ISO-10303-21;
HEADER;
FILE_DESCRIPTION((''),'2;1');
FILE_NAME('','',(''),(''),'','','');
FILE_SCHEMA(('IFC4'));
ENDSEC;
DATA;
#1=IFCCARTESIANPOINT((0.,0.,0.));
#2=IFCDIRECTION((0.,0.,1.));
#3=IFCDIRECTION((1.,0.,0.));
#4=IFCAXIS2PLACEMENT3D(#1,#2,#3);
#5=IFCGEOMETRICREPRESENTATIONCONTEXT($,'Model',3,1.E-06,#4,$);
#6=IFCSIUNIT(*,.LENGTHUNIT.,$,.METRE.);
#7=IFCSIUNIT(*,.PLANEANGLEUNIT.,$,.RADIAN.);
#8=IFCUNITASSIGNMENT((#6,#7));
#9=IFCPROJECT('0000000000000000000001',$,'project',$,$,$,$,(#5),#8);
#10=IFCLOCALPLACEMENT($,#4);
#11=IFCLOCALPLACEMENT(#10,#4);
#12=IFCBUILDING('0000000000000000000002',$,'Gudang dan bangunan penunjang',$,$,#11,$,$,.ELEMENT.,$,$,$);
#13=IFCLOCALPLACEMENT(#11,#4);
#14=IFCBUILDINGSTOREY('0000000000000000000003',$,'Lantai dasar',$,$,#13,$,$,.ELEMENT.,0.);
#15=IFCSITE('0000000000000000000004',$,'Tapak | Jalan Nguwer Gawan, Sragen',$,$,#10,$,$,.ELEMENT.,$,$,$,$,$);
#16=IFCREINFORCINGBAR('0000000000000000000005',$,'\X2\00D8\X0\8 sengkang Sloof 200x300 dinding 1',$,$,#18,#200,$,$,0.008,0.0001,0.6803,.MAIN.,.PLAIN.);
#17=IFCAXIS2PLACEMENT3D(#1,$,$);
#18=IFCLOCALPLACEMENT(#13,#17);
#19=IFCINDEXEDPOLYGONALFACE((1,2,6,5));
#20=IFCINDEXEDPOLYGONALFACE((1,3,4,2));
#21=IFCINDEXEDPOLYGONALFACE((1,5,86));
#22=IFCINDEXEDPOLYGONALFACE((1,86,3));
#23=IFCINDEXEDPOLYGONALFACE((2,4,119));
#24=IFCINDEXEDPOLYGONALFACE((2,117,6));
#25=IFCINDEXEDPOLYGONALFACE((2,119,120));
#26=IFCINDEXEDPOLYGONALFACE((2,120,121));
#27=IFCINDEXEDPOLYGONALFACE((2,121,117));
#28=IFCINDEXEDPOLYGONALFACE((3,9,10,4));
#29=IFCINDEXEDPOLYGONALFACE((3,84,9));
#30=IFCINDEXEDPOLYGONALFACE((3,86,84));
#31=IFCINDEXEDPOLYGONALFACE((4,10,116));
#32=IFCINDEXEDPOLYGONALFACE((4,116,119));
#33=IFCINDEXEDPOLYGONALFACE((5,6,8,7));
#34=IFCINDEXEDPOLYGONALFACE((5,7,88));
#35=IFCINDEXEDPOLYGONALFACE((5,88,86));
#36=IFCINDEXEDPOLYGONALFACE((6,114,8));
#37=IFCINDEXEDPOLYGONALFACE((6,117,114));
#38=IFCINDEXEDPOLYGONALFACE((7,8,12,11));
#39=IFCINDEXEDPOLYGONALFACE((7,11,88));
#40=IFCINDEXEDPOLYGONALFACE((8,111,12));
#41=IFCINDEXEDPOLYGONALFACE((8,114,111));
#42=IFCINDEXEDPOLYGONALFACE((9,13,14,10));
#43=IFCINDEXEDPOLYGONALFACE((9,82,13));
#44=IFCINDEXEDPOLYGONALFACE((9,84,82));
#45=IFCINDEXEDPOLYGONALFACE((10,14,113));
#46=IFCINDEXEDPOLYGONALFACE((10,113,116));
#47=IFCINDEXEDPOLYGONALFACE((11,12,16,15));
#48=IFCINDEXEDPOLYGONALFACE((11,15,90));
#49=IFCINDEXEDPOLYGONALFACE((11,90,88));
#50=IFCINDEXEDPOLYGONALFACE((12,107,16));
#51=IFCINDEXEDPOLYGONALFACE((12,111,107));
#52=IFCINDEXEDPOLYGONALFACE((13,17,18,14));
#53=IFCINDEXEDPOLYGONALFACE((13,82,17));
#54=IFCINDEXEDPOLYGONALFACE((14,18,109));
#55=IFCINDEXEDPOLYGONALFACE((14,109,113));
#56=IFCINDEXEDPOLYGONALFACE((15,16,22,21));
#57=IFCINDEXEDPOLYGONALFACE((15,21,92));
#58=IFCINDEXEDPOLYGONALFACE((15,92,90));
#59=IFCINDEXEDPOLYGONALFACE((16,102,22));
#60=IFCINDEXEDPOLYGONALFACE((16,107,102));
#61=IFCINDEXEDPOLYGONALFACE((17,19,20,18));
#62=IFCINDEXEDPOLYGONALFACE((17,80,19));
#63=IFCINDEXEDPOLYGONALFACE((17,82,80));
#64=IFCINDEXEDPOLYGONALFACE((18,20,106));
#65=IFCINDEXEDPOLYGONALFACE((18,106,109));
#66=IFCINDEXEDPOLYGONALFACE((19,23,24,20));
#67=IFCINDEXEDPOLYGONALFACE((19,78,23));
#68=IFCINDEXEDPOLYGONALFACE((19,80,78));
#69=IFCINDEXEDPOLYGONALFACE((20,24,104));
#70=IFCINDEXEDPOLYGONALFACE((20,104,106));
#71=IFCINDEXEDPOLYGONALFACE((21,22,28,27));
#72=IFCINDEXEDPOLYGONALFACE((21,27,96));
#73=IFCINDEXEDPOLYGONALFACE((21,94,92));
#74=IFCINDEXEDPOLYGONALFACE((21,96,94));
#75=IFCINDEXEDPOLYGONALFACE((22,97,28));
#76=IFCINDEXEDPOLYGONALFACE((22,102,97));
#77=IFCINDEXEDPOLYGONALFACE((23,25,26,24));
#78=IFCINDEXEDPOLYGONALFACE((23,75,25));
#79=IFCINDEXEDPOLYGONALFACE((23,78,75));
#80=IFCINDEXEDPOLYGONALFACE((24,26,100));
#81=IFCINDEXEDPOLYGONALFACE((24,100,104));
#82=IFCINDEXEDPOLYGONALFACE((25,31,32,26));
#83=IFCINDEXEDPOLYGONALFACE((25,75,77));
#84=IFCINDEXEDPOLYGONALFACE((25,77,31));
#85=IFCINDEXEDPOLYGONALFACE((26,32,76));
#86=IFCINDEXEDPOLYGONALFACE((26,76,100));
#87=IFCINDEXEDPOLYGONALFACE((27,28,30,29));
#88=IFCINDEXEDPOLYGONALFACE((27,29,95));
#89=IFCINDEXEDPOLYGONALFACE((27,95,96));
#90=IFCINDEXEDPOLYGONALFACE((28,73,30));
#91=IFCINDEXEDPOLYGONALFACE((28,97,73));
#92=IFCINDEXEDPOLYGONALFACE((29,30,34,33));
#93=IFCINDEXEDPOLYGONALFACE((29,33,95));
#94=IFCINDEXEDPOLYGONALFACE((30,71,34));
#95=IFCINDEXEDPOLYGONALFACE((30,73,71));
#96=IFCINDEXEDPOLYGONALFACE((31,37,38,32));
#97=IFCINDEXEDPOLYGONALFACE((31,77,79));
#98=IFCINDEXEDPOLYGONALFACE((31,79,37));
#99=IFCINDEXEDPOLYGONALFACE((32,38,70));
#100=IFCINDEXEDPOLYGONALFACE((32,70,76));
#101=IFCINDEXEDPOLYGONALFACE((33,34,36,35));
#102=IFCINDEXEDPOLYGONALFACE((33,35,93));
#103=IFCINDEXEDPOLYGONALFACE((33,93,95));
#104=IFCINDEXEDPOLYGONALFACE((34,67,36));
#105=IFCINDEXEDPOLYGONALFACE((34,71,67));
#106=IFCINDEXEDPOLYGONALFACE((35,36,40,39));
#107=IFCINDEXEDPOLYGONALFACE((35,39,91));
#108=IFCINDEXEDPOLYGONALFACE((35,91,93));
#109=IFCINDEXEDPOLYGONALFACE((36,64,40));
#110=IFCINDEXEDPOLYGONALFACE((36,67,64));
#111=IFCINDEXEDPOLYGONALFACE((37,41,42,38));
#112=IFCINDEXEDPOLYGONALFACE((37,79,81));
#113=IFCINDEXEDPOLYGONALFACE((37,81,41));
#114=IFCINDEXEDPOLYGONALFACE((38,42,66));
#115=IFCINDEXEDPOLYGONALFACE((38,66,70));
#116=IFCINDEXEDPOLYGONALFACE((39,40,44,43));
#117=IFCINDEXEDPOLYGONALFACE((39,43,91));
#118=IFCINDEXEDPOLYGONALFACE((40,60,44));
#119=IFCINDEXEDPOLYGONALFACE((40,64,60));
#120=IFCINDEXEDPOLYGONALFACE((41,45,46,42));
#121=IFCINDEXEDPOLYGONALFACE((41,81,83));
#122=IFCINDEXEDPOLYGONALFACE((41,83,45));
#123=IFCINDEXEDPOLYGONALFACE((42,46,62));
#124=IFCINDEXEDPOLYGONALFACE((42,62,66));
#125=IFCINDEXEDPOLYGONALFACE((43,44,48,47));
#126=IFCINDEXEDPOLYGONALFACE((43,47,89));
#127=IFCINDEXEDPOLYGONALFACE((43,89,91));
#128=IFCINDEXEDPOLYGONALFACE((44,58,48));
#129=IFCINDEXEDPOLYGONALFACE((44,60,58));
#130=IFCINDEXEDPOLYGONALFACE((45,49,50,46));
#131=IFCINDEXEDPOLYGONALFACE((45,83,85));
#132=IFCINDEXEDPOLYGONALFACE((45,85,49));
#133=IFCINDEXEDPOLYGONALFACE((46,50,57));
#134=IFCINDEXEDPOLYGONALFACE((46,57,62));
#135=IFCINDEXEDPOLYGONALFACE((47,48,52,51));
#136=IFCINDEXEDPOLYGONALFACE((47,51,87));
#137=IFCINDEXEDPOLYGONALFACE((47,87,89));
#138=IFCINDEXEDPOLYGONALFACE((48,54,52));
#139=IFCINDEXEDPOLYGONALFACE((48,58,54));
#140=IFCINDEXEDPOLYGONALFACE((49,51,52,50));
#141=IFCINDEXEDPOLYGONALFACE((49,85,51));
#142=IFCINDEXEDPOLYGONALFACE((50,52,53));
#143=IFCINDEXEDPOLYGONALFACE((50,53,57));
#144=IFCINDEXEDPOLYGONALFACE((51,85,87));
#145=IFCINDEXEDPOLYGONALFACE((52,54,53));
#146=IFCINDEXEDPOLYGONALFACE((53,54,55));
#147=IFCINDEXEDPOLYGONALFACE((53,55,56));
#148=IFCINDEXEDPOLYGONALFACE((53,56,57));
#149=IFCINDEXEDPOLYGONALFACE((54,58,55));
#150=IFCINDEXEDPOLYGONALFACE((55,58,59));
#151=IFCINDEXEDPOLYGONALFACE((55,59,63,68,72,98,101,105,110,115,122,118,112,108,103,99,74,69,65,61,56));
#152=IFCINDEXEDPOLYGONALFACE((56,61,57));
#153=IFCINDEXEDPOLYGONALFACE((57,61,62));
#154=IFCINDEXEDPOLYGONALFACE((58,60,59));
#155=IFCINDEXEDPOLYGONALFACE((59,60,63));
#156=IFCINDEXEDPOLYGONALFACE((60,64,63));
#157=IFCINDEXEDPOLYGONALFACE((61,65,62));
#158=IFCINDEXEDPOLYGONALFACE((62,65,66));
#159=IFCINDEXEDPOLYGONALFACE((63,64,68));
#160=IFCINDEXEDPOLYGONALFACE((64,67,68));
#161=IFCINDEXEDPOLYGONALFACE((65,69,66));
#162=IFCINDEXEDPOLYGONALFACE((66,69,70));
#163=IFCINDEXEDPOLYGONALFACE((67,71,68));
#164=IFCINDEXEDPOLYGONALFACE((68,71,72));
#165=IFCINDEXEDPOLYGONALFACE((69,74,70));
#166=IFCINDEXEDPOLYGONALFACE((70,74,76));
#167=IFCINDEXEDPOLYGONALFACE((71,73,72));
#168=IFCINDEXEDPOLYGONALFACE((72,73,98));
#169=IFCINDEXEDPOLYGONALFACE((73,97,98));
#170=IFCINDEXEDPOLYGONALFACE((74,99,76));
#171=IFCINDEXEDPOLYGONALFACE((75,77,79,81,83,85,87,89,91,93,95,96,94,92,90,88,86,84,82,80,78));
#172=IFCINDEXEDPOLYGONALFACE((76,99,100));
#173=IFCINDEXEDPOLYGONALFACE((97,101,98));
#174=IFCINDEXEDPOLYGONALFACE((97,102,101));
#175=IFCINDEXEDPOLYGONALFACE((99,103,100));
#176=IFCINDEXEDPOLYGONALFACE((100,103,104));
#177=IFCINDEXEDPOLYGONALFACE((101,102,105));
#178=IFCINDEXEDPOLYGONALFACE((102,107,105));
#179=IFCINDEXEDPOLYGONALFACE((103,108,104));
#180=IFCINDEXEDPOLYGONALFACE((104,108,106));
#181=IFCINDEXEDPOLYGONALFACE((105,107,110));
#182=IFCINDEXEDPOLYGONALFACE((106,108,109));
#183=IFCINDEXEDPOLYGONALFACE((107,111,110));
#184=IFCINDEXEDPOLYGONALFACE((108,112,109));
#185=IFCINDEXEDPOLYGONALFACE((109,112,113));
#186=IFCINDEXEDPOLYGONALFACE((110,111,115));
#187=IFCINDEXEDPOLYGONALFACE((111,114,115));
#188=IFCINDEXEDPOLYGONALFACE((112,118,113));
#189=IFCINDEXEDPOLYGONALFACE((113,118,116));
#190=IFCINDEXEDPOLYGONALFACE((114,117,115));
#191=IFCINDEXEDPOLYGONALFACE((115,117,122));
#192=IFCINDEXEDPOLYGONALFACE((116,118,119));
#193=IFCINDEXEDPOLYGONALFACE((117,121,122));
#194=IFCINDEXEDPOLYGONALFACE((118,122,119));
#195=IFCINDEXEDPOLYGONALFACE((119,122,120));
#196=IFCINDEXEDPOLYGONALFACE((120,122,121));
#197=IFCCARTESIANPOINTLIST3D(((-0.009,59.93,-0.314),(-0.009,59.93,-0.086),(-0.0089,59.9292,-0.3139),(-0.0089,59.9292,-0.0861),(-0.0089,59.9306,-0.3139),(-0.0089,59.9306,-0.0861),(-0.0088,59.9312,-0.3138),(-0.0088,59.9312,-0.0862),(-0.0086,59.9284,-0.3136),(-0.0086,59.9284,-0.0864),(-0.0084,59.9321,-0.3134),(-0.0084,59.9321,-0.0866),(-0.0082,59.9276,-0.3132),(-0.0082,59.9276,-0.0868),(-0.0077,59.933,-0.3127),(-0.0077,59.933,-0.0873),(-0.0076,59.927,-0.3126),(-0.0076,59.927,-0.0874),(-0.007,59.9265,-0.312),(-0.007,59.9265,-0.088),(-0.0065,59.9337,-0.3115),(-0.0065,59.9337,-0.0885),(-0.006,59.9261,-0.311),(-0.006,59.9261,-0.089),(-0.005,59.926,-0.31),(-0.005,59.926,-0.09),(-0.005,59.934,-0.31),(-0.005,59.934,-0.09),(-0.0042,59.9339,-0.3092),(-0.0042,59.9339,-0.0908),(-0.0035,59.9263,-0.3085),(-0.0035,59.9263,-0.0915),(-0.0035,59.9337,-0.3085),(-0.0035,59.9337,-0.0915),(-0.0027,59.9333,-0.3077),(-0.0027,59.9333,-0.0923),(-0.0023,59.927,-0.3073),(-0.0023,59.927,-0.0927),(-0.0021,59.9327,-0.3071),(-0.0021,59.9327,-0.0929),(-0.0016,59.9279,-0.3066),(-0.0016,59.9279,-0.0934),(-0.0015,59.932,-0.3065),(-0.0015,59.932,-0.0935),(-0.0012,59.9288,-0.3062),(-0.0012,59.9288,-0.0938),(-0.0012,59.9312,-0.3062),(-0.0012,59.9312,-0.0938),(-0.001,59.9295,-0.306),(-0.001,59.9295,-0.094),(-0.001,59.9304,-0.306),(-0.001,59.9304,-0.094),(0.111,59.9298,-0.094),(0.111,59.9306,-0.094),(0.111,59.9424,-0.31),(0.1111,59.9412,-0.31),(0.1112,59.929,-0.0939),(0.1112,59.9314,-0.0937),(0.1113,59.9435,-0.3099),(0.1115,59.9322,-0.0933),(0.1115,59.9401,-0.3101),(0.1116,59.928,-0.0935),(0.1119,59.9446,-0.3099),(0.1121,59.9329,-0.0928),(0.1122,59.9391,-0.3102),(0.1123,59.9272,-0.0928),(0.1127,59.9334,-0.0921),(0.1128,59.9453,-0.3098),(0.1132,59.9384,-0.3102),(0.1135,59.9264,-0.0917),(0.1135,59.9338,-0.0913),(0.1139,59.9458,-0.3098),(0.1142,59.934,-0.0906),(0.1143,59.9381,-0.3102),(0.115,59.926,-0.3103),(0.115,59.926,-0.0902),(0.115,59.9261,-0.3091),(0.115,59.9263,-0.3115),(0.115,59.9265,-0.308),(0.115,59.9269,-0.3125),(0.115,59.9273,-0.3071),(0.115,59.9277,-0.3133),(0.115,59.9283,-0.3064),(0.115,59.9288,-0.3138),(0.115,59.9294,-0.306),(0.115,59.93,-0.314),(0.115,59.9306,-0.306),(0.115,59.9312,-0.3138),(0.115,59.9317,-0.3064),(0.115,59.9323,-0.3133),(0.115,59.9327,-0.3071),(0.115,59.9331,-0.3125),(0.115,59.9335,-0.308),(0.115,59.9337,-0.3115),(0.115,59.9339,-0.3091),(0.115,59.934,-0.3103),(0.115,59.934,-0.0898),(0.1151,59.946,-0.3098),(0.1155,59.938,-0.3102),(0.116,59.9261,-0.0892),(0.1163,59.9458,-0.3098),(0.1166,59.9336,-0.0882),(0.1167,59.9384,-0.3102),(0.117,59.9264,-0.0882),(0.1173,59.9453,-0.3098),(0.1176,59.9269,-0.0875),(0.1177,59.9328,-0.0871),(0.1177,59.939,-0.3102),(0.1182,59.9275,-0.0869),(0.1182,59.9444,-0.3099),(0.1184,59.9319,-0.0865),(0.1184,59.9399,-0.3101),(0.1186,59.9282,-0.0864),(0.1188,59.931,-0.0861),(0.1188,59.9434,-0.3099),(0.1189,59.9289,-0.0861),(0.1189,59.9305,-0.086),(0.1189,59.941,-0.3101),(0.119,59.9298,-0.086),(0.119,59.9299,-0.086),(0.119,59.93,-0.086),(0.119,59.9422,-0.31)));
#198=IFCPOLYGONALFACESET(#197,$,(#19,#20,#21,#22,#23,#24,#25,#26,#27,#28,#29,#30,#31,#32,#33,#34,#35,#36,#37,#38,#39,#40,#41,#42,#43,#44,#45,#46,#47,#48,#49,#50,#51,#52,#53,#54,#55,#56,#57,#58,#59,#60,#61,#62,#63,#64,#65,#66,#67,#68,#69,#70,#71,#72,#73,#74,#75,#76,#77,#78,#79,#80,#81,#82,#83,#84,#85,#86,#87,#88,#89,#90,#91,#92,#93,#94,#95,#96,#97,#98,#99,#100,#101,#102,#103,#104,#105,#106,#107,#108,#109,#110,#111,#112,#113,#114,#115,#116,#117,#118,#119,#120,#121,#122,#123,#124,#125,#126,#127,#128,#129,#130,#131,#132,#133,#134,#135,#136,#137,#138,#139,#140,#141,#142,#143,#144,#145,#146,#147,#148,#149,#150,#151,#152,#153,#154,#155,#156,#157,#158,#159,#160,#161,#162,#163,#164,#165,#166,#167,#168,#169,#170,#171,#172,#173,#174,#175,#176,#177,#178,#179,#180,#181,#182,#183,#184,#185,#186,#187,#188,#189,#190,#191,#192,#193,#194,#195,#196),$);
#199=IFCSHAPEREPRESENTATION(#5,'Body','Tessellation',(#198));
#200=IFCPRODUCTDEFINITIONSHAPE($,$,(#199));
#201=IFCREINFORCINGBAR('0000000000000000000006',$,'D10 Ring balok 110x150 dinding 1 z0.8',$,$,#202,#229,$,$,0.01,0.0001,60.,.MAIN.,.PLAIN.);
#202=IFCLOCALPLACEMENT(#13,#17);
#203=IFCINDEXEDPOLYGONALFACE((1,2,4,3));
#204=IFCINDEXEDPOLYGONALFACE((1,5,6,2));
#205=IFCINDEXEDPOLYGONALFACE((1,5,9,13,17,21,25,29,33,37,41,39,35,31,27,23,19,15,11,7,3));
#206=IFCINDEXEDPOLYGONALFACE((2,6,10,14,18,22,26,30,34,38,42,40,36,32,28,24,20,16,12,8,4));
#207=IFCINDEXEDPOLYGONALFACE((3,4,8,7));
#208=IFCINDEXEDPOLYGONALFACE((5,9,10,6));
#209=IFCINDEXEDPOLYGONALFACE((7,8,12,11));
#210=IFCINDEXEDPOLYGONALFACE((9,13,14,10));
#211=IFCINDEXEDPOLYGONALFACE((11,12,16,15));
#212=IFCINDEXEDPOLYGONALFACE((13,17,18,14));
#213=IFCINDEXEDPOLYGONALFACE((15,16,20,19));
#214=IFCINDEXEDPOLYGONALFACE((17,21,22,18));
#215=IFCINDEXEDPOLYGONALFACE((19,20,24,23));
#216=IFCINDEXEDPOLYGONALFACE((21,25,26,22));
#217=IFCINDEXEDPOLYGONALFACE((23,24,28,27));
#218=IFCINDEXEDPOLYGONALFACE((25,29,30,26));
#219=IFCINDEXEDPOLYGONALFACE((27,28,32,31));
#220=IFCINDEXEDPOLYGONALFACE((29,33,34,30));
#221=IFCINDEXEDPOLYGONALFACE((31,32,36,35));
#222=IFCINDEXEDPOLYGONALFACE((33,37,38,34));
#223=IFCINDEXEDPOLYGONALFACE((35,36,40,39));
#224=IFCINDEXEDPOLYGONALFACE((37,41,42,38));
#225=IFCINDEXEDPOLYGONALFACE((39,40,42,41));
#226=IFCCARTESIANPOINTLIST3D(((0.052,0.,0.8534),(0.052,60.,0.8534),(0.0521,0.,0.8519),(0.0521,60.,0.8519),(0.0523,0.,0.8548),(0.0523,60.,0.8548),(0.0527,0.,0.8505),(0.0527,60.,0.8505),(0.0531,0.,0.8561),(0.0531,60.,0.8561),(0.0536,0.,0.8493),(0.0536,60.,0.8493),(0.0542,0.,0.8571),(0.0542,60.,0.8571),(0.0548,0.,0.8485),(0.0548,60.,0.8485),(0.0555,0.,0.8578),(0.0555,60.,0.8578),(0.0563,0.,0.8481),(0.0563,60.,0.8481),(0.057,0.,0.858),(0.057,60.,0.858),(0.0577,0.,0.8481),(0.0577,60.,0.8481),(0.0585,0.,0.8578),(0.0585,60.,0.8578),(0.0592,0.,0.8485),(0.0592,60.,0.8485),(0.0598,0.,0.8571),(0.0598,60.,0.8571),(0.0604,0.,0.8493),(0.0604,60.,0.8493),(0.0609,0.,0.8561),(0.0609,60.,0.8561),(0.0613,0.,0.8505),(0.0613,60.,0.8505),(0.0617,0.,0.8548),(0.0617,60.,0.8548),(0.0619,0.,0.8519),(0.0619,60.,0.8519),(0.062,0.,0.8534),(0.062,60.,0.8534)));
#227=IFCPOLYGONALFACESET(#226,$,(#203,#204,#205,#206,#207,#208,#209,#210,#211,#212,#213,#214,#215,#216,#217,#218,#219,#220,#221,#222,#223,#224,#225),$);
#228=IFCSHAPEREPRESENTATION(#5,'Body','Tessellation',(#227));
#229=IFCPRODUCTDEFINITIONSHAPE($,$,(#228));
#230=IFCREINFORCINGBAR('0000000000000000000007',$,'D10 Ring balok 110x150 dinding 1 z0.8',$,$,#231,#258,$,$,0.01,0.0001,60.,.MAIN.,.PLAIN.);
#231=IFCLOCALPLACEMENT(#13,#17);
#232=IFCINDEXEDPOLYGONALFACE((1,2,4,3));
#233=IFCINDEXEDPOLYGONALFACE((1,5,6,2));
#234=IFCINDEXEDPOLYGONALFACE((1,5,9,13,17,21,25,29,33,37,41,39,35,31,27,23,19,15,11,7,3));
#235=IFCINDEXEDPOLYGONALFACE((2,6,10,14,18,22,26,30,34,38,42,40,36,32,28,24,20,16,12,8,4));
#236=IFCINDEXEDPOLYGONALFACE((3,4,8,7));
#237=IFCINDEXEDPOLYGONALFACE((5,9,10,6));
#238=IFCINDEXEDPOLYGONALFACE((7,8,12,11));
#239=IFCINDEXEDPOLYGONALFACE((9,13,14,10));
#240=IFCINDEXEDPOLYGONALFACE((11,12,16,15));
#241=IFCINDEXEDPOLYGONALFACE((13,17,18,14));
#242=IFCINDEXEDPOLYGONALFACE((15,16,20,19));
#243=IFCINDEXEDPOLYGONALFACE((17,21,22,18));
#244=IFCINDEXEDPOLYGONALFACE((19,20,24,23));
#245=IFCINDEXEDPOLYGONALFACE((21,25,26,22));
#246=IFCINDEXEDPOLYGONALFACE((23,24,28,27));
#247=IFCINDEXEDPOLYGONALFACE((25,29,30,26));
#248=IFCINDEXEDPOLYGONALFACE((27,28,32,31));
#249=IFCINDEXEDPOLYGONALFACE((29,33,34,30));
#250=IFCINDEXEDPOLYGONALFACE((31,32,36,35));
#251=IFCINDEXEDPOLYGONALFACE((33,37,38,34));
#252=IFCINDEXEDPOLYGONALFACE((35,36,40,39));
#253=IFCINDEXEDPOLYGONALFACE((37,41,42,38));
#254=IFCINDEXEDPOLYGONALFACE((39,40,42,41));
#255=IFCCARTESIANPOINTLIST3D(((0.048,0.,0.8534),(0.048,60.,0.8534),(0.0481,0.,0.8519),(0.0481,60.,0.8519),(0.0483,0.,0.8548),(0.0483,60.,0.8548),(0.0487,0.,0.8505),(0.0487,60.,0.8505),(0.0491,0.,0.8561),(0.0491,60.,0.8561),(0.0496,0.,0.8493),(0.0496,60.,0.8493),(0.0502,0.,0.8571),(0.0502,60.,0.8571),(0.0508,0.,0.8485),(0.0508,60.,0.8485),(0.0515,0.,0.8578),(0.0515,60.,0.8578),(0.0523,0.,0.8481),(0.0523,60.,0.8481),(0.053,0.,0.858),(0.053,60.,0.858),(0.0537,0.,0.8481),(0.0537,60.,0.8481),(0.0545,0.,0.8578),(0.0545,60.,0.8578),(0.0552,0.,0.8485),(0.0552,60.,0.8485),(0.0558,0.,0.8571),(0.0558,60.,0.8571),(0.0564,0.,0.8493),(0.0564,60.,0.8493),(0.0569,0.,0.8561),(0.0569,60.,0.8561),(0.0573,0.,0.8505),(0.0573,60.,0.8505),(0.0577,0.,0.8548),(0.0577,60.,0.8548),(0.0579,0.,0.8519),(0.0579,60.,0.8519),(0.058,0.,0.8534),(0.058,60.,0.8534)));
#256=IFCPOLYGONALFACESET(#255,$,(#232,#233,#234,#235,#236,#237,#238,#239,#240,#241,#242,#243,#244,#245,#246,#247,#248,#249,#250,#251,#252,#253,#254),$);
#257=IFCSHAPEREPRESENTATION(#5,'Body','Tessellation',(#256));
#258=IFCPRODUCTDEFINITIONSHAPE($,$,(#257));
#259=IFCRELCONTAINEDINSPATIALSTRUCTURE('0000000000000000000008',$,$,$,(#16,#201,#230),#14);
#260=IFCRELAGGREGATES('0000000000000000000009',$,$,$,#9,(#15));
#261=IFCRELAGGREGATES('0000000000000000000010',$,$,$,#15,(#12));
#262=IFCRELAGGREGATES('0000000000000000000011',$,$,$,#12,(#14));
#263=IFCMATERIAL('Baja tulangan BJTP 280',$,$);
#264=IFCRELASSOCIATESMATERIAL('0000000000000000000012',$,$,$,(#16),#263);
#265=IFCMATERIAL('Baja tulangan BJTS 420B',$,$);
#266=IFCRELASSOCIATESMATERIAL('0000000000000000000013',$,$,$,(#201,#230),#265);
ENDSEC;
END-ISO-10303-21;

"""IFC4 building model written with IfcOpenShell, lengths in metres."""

from ifc_helpers import new_model, entity, si_unit, origin_with_axes, place, context, project, spatial, material, element, save


model = new_model("IFC4")

# Units and contexts
model_context = context("Model", 3, precision=1e-06, world=origin_with_axes())
ifc_project = project(units=[si_unit("LENGTHUNIT", "METRE"), si_unit("PLANEANGLEUNIT", "RADIAN")], contexts=[model_context])

# Site, building, storey
site_placement = place(None, origin_with_axes())
site = spatial("IfcSite", under=ifc_project, at=site_placement, Name="Tapak | Jalan Nguwer Gawan, Sragen", CompositionType="ELEMENT")
building_placement = place(site_placement, origin_with_axes())
building = spatial("IfcBuilding", under=site, at=building_placement, Name="Gudang dan bangunan penunjang", CompositionType="ELEMENT")
storey_placement = place(building_placement, origin_with_axes())
storey = spatial("IfcBuildingStorey", under=building, at=storey_placement, Name="Lantai dasar", CompositionType="ELEMENT", Elevation=0.0)

# Shared definitions
placement = place(None, origin_with_axes())

# Reinforcing bars
ifc_material_1 = material(Name="Baja tulangan BJTP 280")
element("IfcReinforcingBar", 1, at=placement, inside=storey, material=ifc_material_1, Name="Ø8 sengkang Sloof 200x300 dinding 1", BarLength=0.6803, BarSurface="PLAIN", CrossSectionArea=0.0001, NominalDiameter=0.008, PredefinedType="MAIN", context=model_context, shape_type="AdvancedSweptSolid", body=[
    entity("IfcSweptDiskSolid", entity("IfcPolyline", [entity("IfcCartesianPoint", [0.115, 59.93, -0.31]), entity("IfcCartesianPoint", [-0.005, 59.93, -0.31]), entity("IfcCartesianPoint", [-0.005, 59.93, -0.09]), entity("IfcCartesianPoint", [0.115, 59.93, -0.09]), entity("IfcCartesianPoint", [0.115, 59.942, -0.31])]), 0.004),
])
ifc_material_2 = material(Name="Baja tulangan BJTS 420B")
element("IfcReinforcingBar", 2, at=placement, inside=storey, material=ifc_material_2, Name="D10 Ring balok 110x150 dinding 1 z0.8", BarLength=60.0, BarSurface="PLAIN", CrossSectionArea=0.0001, NominalDiameter=0.01, PredefinedType="MAIN", context=model_context, shape_type="AdvancedSweptSolid", body=[
    entity("IfcSweptDiskSolid", entity("IfcPolyline", [entity("IfcCartesianPoint", [0.057, 0.0, 0.853]), entity("IfcCartesianPoint", [0.057, 60.0, 0.853])]), 0.005),
])
element("IfcReinforcingBar", 3, at=placement, inside=storey, material=ifc_material_2, Name="D10 Ring balok 110x150 dinding 1 z0.8", BarLength=60.0, BarSurface="PLAIN", CrossSectionArea=0.0001, NominalDiameter=0.01, PredefinedType="MAIN", context=model_context, shape_type="AdvancedSweptSolid", body=[
    entity("IfcSweptDiskSolid", entity("IfcPolyline", [entity("IfcCartesianPoint", [0.053, 0.0, 0.853]), entity("IfcCartesianPoint", [0.053, 60.0, 0.853])]), 0.005),
])

save(model, "model.ifc")
